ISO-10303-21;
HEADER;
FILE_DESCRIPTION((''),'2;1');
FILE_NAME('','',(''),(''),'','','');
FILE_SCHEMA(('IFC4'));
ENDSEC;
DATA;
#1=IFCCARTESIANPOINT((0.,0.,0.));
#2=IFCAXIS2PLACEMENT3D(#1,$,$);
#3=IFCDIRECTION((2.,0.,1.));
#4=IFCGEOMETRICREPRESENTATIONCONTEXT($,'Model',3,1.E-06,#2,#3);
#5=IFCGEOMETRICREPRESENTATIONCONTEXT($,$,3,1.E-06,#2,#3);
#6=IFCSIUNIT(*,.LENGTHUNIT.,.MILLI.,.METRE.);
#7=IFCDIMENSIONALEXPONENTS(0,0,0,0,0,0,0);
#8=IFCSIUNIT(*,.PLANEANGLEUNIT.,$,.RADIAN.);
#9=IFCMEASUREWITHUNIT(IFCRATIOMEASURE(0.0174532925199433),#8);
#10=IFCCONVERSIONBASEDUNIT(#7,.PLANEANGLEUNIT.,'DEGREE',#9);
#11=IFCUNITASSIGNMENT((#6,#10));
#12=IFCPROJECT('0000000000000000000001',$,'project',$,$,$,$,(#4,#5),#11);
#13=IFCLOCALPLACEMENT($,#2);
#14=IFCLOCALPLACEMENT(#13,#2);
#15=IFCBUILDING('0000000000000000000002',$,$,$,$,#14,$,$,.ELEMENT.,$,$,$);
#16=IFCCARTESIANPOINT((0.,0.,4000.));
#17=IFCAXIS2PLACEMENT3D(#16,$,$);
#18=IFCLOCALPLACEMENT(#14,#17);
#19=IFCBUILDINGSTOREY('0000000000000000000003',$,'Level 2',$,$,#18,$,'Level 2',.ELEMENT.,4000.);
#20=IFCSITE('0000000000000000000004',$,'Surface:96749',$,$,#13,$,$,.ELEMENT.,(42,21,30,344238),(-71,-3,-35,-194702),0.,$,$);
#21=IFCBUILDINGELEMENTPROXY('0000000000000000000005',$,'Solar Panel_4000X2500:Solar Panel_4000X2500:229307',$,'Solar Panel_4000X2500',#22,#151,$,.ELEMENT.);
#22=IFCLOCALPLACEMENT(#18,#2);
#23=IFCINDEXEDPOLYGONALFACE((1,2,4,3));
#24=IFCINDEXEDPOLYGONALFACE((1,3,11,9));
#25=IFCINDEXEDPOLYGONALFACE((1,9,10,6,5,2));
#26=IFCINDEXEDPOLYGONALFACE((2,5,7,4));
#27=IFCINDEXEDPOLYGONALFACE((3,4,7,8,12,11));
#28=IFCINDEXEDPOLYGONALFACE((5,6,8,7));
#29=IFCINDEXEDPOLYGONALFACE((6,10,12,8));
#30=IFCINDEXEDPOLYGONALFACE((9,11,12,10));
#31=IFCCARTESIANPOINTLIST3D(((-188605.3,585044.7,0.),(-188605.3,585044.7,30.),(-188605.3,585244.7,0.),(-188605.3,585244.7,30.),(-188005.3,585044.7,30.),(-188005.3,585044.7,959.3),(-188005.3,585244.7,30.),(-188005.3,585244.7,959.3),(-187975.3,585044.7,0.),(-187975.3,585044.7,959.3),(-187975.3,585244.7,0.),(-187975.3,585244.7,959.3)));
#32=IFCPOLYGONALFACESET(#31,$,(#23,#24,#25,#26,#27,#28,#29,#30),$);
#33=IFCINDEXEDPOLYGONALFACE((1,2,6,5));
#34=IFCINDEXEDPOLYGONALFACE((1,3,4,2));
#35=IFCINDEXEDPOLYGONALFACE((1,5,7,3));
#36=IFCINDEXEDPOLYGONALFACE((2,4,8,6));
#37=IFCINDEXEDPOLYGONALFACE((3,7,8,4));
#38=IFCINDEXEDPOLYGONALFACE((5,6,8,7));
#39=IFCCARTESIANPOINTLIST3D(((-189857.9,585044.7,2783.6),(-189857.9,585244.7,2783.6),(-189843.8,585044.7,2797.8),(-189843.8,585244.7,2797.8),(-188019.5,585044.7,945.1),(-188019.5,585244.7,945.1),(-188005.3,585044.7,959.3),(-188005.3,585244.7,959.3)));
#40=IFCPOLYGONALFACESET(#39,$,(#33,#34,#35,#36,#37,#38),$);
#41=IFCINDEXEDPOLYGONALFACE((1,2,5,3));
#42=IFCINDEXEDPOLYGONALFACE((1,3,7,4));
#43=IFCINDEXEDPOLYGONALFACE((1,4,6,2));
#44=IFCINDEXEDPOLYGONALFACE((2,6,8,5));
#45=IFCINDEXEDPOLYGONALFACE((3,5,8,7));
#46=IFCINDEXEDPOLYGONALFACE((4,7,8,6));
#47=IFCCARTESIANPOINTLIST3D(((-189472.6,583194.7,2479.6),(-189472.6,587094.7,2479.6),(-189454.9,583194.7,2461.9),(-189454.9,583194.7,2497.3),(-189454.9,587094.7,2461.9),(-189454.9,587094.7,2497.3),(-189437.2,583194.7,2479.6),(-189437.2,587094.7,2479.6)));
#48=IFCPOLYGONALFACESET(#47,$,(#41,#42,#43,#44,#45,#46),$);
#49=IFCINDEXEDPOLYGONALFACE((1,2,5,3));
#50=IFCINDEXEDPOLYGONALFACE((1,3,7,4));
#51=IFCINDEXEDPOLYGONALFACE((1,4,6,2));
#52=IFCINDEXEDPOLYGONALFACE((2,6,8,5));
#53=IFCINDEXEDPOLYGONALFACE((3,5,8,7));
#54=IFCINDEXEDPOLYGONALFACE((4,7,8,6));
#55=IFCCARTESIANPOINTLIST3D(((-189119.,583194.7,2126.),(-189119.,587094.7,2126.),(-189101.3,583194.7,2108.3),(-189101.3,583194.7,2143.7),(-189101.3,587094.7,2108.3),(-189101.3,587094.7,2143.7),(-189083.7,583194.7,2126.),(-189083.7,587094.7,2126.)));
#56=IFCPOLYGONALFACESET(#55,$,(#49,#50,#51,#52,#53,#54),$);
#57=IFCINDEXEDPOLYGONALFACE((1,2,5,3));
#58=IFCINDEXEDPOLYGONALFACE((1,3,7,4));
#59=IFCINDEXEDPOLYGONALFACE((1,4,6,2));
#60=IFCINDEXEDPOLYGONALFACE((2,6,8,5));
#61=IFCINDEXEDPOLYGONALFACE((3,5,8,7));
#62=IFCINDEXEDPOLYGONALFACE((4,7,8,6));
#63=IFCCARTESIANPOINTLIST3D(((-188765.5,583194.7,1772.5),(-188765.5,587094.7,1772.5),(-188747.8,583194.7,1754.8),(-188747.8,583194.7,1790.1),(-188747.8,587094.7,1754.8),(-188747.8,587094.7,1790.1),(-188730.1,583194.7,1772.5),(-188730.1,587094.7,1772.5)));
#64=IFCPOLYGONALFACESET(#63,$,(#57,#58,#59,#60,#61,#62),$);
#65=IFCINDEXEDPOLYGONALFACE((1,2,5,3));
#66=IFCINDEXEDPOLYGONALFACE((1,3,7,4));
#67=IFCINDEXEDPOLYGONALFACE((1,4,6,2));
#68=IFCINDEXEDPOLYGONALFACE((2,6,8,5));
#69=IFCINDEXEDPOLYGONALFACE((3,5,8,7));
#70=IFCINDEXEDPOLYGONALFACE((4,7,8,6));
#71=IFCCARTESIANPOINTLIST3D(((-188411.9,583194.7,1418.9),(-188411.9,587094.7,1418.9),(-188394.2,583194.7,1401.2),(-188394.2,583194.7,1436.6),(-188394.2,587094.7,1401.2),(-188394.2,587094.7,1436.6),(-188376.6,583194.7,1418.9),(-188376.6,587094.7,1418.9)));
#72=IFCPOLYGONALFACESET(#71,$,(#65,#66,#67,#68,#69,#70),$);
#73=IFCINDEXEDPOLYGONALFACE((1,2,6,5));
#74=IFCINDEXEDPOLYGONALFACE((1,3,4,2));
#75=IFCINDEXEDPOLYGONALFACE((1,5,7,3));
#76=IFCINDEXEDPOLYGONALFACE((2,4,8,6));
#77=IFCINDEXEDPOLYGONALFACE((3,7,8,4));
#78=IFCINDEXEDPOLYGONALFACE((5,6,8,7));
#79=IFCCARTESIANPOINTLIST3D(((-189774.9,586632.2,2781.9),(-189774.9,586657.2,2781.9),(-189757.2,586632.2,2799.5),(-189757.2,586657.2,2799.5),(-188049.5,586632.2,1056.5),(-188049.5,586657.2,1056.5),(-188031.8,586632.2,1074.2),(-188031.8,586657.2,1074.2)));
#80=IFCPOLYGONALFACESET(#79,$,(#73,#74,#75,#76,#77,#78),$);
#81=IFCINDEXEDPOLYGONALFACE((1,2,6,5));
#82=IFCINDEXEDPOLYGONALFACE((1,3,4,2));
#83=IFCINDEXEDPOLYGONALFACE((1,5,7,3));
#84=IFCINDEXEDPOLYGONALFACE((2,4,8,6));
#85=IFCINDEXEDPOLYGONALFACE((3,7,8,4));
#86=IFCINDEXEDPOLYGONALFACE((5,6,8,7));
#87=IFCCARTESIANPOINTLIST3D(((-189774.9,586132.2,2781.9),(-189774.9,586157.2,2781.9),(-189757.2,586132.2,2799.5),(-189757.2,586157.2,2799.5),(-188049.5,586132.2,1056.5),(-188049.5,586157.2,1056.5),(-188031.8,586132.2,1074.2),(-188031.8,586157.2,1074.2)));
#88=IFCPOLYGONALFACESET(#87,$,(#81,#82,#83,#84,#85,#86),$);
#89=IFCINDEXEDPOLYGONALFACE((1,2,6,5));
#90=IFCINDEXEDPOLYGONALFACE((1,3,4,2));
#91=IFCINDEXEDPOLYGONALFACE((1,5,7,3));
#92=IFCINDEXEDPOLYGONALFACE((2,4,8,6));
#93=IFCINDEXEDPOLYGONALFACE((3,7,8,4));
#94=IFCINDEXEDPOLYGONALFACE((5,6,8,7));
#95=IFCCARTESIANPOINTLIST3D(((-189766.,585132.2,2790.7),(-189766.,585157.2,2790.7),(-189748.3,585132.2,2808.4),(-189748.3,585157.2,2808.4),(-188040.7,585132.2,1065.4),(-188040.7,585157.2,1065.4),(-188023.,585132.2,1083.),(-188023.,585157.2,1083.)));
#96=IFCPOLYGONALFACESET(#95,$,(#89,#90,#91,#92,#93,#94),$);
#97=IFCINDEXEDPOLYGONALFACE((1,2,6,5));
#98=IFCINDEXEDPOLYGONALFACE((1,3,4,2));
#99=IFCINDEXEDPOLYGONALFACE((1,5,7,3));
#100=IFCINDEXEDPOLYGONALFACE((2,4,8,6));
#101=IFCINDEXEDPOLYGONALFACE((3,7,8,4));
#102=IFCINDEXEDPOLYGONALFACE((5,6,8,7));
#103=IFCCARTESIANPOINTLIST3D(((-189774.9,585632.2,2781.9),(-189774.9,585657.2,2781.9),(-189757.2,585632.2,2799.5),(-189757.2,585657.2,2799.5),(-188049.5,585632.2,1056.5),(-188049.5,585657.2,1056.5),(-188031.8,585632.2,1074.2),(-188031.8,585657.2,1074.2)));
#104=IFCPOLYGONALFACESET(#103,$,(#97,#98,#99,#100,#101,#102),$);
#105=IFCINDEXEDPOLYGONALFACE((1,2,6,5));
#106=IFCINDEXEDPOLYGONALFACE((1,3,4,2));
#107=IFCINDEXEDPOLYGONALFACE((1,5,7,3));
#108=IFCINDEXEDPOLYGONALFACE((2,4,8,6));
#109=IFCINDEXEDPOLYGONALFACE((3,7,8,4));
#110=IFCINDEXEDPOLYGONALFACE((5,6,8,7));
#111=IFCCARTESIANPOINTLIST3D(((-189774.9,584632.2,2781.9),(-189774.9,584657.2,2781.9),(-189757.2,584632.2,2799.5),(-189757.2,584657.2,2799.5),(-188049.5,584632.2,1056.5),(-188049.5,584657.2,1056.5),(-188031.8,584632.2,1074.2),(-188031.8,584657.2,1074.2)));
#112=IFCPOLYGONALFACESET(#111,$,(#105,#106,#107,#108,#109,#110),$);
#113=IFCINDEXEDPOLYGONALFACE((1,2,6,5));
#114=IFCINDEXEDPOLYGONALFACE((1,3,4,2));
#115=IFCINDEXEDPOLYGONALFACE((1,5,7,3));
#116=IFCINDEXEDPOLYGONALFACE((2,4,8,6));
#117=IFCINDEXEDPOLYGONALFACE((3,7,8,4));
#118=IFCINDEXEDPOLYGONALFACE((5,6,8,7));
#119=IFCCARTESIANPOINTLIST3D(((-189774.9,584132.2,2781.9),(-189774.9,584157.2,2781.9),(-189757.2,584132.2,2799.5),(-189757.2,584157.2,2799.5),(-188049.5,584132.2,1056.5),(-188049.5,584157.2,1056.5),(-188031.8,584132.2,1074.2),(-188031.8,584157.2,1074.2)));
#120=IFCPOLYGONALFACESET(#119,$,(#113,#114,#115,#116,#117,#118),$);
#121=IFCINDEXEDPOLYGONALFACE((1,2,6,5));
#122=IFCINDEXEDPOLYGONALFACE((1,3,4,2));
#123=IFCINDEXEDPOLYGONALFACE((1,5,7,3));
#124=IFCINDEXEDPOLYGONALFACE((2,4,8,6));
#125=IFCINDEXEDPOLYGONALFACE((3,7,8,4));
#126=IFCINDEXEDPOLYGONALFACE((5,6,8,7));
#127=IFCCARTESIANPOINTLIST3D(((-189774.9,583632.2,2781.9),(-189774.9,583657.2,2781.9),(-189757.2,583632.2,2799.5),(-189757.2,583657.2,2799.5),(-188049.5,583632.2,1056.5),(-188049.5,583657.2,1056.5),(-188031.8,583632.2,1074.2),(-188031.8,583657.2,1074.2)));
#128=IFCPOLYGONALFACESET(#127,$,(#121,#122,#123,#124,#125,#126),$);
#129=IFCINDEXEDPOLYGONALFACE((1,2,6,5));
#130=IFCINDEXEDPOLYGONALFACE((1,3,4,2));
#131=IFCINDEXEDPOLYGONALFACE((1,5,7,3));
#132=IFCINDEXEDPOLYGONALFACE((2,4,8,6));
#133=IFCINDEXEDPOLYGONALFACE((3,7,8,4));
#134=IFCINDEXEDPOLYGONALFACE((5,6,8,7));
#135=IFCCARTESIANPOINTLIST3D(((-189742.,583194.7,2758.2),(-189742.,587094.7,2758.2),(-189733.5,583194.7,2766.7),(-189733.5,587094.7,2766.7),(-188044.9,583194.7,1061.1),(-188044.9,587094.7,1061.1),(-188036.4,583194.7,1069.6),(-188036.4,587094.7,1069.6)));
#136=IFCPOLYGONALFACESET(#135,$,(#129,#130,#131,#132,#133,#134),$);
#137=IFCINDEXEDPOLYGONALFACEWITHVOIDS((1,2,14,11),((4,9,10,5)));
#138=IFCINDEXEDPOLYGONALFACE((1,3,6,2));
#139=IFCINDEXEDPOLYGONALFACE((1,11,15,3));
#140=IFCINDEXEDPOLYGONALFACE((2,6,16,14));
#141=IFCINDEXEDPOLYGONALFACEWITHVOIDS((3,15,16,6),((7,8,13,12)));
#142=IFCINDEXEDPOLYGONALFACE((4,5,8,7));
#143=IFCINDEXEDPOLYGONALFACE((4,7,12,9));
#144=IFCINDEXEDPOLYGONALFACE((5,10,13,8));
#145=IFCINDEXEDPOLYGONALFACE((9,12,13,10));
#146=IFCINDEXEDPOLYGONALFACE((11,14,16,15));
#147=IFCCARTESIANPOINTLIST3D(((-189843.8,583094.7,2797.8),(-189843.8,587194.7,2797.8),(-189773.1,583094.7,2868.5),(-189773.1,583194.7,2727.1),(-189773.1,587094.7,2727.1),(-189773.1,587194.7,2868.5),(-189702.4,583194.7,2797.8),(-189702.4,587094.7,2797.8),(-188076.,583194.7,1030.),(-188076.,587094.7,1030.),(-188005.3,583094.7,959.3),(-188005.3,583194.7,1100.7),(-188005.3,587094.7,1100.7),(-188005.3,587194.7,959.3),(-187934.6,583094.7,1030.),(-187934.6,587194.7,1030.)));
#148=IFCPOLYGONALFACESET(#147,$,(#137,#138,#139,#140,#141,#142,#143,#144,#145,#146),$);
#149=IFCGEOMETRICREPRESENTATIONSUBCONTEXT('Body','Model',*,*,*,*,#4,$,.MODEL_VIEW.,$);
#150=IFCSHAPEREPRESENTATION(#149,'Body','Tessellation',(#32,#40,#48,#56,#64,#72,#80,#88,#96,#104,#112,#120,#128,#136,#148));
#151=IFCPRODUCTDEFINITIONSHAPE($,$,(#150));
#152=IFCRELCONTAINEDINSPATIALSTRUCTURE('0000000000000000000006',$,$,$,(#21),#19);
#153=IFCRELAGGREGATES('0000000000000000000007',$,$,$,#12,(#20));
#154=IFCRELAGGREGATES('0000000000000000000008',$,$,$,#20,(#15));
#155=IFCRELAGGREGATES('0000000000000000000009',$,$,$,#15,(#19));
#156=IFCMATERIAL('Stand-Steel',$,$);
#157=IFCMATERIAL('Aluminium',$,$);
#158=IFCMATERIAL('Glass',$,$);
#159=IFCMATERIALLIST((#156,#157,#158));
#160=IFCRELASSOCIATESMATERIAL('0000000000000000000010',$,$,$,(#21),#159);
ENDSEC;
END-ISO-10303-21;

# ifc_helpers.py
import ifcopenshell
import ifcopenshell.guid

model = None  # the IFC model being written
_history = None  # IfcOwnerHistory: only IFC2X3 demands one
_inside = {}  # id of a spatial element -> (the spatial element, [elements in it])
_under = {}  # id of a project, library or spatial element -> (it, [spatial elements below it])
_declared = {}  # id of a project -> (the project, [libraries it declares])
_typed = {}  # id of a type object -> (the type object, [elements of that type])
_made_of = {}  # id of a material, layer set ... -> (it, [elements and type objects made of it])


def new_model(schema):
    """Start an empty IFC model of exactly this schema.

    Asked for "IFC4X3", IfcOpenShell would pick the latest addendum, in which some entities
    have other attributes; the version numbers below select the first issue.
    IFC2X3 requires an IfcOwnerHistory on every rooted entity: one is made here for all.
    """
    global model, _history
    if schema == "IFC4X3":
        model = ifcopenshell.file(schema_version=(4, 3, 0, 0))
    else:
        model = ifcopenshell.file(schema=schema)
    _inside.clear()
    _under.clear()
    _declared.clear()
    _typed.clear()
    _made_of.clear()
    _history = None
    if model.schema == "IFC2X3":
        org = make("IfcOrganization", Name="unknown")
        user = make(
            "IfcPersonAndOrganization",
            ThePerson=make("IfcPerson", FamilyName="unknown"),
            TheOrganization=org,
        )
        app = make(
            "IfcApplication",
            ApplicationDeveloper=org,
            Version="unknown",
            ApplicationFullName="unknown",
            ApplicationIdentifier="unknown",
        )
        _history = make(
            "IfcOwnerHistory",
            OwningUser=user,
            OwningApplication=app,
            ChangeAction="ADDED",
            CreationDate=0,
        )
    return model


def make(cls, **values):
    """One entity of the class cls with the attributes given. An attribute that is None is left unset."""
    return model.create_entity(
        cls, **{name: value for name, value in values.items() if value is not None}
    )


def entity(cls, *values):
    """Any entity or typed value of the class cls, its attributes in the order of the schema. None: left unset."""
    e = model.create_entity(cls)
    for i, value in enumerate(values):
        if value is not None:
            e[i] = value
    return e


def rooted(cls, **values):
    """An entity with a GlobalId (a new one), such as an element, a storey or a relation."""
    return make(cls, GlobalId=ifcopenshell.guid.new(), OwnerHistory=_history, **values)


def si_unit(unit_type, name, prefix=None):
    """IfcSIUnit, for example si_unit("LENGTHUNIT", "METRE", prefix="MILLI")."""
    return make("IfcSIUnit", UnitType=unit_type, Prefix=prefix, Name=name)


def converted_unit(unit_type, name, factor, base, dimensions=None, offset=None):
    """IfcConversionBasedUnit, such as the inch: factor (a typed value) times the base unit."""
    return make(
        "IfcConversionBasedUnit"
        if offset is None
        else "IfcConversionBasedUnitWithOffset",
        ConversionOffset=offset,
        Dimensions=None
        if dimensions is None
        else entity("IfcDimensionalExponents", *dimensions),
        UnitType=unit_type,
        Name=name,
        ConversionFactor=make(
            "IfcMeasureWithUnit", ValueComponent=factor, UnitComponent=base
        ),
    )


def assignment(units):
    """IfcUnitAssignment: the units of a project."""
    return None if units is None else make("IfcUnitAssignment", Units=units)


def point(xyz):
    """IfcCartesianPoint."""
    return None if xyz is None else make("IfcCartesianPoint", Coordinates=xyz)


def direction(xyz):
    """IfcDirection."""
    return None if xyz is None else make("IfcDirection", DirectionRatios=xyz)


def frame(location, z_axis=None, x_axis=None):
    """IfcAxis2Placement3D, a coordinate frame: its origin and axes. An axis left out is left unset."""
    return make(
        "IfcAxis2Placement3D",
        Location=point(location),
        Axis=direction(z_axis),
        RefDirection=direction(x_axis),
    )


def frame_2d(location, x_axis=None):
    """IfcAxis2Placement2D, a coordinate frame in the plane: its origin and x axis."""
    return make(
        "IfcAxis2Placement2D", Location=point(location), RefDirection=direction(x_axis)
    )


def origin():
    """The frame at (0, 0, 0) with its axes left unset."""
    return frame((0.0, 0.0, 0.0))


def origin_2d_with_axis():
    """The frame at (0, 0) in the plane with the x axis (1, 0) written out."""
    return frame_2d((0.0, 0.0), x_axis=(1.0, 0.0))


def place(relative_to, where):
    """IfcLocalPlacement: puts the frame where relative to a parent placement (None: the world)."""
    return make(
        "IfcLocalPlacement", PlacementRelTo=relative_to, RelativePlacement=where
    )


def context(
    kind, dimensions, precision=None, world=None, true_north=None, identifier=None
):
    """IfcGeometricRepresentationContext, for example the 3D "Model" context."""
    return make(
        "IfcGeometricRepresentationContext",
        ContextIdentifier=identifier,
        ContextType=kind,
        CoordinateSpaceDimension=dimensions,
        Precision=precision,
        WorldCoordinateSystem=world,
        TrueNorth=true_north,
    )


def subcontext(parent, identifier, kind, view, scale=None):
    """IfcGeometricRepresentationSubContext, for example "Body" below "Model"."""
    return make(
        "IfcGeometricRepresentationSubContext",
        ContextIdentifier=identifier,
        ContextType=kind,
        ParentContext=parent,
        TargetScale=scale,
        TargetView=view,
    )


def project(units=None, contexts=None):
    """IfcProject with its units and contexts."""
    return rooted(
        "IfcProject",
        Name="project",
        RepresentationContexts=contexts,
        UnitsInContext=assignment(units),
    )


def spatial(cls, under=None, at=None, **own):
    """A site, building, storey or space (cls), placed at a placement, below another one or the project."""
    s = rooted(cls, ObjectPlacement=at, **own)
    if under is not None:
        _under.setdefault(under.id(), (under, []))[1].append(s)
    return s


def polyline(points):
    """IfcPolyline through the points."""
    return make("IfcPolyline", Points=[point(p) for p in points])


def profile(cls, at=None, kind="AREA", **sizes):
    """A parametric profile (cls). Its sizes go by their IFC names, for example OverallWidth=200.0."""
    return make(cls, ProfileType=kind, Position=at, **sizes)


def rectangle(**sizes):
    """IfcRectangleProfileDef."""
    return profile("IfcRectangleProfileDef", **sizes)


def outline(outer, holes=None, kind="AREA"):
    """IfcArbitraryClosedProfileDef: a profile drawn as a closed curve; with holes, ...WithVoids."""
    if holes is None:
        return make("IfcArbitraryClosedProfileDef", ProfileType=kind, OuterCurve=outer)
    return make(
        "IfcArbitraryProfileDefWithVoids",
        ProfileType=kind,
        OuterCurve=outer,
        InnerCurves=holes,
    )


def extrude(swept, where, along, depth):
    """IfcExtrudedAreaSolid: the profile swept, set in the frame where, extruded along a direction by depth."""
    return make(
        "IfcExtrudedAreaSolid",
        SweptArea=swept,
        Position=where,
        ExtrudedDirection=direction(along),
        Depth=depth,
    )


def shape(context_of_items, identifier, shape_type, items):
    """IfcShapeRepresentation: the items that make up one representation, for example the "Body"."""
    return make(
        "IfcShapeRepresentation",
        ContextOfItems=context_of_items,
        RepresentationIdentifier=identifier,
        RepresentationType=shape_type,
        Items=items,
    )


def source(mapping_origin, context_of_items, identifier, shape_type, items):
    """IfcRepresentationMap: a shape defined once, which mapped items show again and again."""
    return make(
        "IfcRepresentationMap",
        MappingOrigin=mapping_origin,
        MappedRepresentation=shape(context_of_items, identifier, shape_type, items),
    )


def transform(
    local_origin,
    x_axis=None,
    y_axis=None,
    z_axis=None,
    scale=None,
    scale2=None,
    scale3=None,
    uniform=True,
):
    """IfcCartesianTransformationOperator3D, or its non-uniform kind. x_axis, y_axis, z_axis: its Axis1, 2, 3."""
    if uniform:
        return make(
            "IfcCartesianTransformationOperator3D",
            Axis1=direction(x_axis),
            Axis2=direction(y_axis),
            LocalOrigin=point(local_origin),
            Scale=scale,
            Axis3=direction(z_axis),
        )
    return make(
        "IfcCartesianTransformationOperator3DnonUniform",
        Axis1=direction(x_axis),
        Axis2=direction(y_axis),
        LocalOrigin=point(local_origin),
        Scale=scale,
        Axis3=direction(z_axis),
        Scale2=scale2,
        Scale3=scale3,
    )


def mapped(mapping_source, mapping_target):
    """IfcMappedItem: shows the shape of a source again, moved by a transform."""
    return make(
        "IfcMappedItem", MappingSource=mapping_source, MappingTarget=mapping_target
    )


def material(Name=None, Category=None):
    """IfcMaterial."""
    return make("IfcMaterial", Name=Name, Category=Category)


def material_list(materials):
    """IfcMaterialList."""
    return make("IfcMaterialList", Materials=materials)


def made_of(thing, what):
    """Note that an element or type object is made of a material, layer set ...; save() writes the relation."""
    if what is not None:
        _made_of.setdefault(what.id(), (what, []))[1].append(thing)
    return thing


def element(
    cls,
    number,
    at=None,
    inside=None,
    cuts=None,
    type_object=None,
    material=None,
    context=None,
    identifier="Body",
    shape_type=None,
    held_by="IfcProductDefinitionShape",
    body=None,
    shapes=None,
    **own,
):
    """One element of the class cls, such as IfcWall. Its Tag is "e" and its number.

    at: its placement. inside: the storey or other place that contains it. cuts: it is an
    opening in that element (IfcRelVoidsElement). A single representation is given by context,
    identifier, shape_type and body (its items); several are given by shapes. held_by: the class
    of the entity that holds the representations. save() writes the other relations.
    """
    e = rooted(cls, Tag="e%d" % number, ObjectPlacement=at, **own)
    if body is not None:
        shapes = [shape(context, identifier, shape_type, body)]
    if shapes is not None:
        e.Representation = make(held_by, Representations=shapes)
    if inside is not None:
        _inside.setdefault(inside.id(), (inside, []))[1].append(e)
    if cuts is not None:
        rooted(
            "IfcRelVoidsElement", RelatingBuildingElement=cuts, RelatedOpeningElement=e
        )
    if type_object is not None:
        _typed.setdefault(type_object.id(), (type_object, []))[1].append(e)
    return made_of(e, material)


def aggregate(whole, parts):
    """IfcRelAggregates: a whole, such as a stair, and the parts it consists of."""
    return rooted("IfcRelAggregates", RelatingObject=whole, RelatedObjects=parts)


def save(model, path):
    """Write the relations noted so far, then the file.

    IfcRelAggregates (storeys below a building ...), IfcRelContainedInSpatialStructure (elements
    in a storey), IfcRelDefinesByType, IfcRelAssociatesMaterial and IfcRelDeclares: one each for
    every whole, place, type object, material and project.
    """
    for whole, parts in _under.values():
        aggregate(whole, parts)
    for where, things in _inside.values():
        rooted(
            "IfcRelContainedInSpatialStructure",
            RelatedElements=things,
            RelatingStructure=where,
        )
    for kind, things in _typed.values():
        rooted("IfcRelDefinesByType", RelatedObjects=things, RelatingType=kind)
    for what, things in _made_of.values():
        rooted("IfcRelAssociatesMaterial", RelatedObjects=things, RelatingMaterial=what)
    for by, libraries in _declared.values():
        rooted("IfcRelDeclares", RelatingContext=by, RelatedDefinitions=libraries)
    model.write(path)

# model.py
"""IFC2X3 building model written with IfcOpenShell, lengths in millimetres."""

from ifc_helpers import new_model, entity, si_unit, converted_unit, direction, frame, frame_2d, origin, origin_2d_with_axis, place, context, subcontext, project, spatial, polyline, rectangle, outline, extrude, source, transform, mapped, material, material_list, element, save


model = new_model("IFC2X3")

# Units and contexts
model_context = context("Model", 3, precision=1e-06, world=origin(), true_north=direction((2.0, 0.0, 1.0)))
context_of_model = context(None, 3, precision=1e-06, world=origin(), true_north=direction((2.0, 0.0, 1.0)))
body_context = subcontext(model_context, "Body", "Model", "MODEL_VIEW")
ifc_project = project(units=[si_unit("LENGTHUNIT", "METRE", prefix="MILLI"), converted_unit("PLANEANGLEUNIT", "DEGREE", entity("IfcRatioMeasure", 0.0174532925199433), si_unit("PLANEANGLEUNIT", "RADIAN"), dimensions=[0, 0, 0, 0, 0, 0, 0])], contexts=[model_context, context_of_model])

# Site, building, storey
site_placement = place(None, origin())
site = spatial("IfcSite", under=ifc_project, at=site_placement, Name="Surface:96749", CompositionType="ELEMENT", RefLatitude=(42, 21, 30, 344238), RefLongitude=(-71, -3, -35, -194702), RefElevation=0.0)
building_placement = place(site_placement, origin())
building = spatial("IfcBuilding", under=site, at=building_placement, CompositionType="ELEMENT")
storey_placement = place(building_placement, frame((0.0, 0.0, 4000.0)))
storey = spatial("IfcBuildingStorey", under=building, at=storey_placement, Name="Level 2", LongName="Level 2", CompositionType="ELEMENT", Elevation=4000.0)

# Building element proxy
ifc_material_1 = material(Name="Stand-Steel")
ifc_material_2 = material(Name="Aluminium")
ifc_material_3 = material(Name="Glass")
shared_shape = source(origin(), body_context, "Body", "SweptSolid", [
    extrude(outline(polyline([(-629.5, -220.0), (329.8, -220.0), (329.8, 410.0), (299.8, 410.0), (299.8, -190.0), (-629.5, -190.0), (-629.5, -220.0)])), frame((-190.0, -100.0, 299.8), z_axis=(0.0, 1.0, 0.0), x_axis=(0.0, 0.0, -1.0)), (0.0, 0.0, 1.0), 200.0),
    extrude(rectangle(XDim=20.0, YDim=200.0, at=frame_2d((0.0, 0.0), x_axis=(0.0, 1.0))), frame((-7.1, 0.0, 922.2), z_axis=(-0.707107, 0.0, 0.707107), x_axis=(0.0, 1.0, 0.0)), (0.0, 0.0, 1.0), 2600.0),
    extrude(rectangle(XDim=25.0, YDim=25.0, at=frame_2d((0.0, 0.0), x_axis=(1.0, 0.0))), frame((-1449.6, -1950.0, 2449.6), z_axis=(0.0, 1.0, 0.0), x_axis=(-0.707107, 0.0, -0.707107)), (0.0, 0.0, 1.0), 3900.0),
    extrude(rectangle(XDim=25.0, YDim=25.0, at=origin_2d_with_axis()), frame((-1096.0, -1950.0, 2096.0), z_axis=(0.0, 1.0, 0.0), x_axis=(-0.707107, 0.0, -0.707107)), (0.0, 0.0, 1.0), 3900.0),
    extrude(rectangle(XDim=25.0, YDim=25.0, at=origin_2d_with_axis()), frame((-742.5, -1950.0, 1742.5), z_axis=(0.0, 1.0, 0.0), x_axis=(-0.707107, 0.0, -0.707107)), (0.0, 0.0, 1.0), 3900.0),
    extrude(rectangle(XDim=25.0, YDim=25.0, at=frame_2d((0.0, 0.0), x_axis=(1.0, 0.0))), frame((-388.9, -1950.0, 1388.9), z_axis=(0.0, 1.0, 0.0), x_axis=(-0.707107, 0.0, -0.707107)), (0.0, 0.0, 1.0), 3900.0),
    extrude(rectangle(XDim=25.0, YDim=25.0, at=frame_2d((0.0, 0.0), x_axis=(0.0, 1.0))), frame((-35.4, 1500.0, 1035.4), z_axis=(-0.707107, 0.0, 0.707107), x_axis=(0.0, 1.0, 0.0)), (0.0, 0.0, 1.0), 2440.0),
    extrude(rectangle(XDim=25.0, YDim=25.0, at=frame_2d((0.0, 0.0), x_axis=(0.0, 1.0))), frame((-35.4, 1000.0, 1035.4), z_axis=(-0.707107, 0.0, 0.707107), x_axis=(0.0, 1.0, 0.0)), (0.0, 0.0, 1.0), 2440.0),
    extrude(rectangle(XDim=25.0, YDim=25.0, at=frame_2d((0.0, 0.0), x_axis=(0.0, 1.0))), frame((-26.5, 0.0, 1044.2), z_axis=(-0.707107, 0.0, 0.707107), x_axis=(0.0, -1.0, 0.0)), (0.0, 0.0, 1.0), 2440.0),
    extrude(rectangle(XDim=25.0, YDim=25.0, at=frame_2d((0.0, 0.0), x_axis=(0.0, 1.0))), frame((-35.4, 500.0, 1035.4), z_axis=(-0.707107, 0.0, 0.707107), x_axis=(0.0, 1.0, 0.0)), (0.0, 0.0, 1.0), 2440.0),
    extrude(rectangle(XDim=25.0, YDim=25.0, at=frame_2d((0.0, 0.0), x_axis=(0.0, 1.0))), frame((-35.4, -500.0, 1035.4), z_axis=(-0.707107, 0.0, 0.707107), x_axis=(0.0, 1.0, 0.0)), (0.0, 0.0, 1.0), 2440.0),
    extrude(rectangle(XDim=25.0, YDim=25.0, at=frame_2d((0.0, 0.0), x_axis=(0.0, 1.0))), frame((-35.4, -1000.0, 1035.4), z_axis=(-0.707107, 0.0, 0.707107), x_axis=(0.0, 1.0, 0.0)), (0.0, 0.0, 1.0), 2440.0),
    extrude(rectangle(XDim=25.0, YDim=25.0, at=frame_2d((0.0, 0.0), x_axis=(0.0, 1.0))), frame((-35.4, -1500.0, 1035.4), z_axis=(-0.707107, 0.0, 0.707107), x_axis=(0.0, 1.0, 0.0)), (0.0, 0.0, 1.0), 2440.0),
    extrude(rectangle(XDim=2400.0, YDim=12.0, at=frame_2d((0.0, 0.0), x_axis=(1.0, 0.0))), frame((-883.9, -1950.0, 1883.9), z_axis=(0.0, 1.0, 0.0), x_axis=(0.707107, 0.0, -0.707107)), (0.0, 0.0, 1.0), 3900.0),
    extrude(outline(polyline([(-2050.0, -1300.0), (2050.0, -1300.0), (2050.0, 1300.0), (-2050.0, 1300.0), (-2050.0, -1300.0)]), holes=[polyline([(1950.0, -1200.0), (-1950.0, -1200.0), (-1950.0, 1200.0), (1950.0, 1200.0), (1950.0, -1200.0)])]), frame((-919.2, 0.0, 1848.5), z_axis=(0.707107, 0.0, 0.707107), x_axis=(0.0, 1.0, 0.0)), (0.0, 0.0, 1.0), 100.0),
])
ifc_material_list_1 = material_list([ifc_material_1, ifc_material_2, ifc_material_3])
proxy_1_placement = place(storey_placement, frame((-188005.3, 585144.7, 30.0)))
element("IfcBuildingElementProxy", 1, at=proxy_1_placement, inside=storey, material=ifc_material_list_1, Name="Solar Panel_4000X2500:Solar Panel_4000X2500:229307", ObjectType="Solar Panel_4000X2500", CompositionType="ELEMENT", context=body_context, shape_type="MappedRepresentation", body=[
    mapped(shared_shape, transform((0.0, 0.0, 0.0), scale=1.0)),
])

save(model, "model.ifc")
